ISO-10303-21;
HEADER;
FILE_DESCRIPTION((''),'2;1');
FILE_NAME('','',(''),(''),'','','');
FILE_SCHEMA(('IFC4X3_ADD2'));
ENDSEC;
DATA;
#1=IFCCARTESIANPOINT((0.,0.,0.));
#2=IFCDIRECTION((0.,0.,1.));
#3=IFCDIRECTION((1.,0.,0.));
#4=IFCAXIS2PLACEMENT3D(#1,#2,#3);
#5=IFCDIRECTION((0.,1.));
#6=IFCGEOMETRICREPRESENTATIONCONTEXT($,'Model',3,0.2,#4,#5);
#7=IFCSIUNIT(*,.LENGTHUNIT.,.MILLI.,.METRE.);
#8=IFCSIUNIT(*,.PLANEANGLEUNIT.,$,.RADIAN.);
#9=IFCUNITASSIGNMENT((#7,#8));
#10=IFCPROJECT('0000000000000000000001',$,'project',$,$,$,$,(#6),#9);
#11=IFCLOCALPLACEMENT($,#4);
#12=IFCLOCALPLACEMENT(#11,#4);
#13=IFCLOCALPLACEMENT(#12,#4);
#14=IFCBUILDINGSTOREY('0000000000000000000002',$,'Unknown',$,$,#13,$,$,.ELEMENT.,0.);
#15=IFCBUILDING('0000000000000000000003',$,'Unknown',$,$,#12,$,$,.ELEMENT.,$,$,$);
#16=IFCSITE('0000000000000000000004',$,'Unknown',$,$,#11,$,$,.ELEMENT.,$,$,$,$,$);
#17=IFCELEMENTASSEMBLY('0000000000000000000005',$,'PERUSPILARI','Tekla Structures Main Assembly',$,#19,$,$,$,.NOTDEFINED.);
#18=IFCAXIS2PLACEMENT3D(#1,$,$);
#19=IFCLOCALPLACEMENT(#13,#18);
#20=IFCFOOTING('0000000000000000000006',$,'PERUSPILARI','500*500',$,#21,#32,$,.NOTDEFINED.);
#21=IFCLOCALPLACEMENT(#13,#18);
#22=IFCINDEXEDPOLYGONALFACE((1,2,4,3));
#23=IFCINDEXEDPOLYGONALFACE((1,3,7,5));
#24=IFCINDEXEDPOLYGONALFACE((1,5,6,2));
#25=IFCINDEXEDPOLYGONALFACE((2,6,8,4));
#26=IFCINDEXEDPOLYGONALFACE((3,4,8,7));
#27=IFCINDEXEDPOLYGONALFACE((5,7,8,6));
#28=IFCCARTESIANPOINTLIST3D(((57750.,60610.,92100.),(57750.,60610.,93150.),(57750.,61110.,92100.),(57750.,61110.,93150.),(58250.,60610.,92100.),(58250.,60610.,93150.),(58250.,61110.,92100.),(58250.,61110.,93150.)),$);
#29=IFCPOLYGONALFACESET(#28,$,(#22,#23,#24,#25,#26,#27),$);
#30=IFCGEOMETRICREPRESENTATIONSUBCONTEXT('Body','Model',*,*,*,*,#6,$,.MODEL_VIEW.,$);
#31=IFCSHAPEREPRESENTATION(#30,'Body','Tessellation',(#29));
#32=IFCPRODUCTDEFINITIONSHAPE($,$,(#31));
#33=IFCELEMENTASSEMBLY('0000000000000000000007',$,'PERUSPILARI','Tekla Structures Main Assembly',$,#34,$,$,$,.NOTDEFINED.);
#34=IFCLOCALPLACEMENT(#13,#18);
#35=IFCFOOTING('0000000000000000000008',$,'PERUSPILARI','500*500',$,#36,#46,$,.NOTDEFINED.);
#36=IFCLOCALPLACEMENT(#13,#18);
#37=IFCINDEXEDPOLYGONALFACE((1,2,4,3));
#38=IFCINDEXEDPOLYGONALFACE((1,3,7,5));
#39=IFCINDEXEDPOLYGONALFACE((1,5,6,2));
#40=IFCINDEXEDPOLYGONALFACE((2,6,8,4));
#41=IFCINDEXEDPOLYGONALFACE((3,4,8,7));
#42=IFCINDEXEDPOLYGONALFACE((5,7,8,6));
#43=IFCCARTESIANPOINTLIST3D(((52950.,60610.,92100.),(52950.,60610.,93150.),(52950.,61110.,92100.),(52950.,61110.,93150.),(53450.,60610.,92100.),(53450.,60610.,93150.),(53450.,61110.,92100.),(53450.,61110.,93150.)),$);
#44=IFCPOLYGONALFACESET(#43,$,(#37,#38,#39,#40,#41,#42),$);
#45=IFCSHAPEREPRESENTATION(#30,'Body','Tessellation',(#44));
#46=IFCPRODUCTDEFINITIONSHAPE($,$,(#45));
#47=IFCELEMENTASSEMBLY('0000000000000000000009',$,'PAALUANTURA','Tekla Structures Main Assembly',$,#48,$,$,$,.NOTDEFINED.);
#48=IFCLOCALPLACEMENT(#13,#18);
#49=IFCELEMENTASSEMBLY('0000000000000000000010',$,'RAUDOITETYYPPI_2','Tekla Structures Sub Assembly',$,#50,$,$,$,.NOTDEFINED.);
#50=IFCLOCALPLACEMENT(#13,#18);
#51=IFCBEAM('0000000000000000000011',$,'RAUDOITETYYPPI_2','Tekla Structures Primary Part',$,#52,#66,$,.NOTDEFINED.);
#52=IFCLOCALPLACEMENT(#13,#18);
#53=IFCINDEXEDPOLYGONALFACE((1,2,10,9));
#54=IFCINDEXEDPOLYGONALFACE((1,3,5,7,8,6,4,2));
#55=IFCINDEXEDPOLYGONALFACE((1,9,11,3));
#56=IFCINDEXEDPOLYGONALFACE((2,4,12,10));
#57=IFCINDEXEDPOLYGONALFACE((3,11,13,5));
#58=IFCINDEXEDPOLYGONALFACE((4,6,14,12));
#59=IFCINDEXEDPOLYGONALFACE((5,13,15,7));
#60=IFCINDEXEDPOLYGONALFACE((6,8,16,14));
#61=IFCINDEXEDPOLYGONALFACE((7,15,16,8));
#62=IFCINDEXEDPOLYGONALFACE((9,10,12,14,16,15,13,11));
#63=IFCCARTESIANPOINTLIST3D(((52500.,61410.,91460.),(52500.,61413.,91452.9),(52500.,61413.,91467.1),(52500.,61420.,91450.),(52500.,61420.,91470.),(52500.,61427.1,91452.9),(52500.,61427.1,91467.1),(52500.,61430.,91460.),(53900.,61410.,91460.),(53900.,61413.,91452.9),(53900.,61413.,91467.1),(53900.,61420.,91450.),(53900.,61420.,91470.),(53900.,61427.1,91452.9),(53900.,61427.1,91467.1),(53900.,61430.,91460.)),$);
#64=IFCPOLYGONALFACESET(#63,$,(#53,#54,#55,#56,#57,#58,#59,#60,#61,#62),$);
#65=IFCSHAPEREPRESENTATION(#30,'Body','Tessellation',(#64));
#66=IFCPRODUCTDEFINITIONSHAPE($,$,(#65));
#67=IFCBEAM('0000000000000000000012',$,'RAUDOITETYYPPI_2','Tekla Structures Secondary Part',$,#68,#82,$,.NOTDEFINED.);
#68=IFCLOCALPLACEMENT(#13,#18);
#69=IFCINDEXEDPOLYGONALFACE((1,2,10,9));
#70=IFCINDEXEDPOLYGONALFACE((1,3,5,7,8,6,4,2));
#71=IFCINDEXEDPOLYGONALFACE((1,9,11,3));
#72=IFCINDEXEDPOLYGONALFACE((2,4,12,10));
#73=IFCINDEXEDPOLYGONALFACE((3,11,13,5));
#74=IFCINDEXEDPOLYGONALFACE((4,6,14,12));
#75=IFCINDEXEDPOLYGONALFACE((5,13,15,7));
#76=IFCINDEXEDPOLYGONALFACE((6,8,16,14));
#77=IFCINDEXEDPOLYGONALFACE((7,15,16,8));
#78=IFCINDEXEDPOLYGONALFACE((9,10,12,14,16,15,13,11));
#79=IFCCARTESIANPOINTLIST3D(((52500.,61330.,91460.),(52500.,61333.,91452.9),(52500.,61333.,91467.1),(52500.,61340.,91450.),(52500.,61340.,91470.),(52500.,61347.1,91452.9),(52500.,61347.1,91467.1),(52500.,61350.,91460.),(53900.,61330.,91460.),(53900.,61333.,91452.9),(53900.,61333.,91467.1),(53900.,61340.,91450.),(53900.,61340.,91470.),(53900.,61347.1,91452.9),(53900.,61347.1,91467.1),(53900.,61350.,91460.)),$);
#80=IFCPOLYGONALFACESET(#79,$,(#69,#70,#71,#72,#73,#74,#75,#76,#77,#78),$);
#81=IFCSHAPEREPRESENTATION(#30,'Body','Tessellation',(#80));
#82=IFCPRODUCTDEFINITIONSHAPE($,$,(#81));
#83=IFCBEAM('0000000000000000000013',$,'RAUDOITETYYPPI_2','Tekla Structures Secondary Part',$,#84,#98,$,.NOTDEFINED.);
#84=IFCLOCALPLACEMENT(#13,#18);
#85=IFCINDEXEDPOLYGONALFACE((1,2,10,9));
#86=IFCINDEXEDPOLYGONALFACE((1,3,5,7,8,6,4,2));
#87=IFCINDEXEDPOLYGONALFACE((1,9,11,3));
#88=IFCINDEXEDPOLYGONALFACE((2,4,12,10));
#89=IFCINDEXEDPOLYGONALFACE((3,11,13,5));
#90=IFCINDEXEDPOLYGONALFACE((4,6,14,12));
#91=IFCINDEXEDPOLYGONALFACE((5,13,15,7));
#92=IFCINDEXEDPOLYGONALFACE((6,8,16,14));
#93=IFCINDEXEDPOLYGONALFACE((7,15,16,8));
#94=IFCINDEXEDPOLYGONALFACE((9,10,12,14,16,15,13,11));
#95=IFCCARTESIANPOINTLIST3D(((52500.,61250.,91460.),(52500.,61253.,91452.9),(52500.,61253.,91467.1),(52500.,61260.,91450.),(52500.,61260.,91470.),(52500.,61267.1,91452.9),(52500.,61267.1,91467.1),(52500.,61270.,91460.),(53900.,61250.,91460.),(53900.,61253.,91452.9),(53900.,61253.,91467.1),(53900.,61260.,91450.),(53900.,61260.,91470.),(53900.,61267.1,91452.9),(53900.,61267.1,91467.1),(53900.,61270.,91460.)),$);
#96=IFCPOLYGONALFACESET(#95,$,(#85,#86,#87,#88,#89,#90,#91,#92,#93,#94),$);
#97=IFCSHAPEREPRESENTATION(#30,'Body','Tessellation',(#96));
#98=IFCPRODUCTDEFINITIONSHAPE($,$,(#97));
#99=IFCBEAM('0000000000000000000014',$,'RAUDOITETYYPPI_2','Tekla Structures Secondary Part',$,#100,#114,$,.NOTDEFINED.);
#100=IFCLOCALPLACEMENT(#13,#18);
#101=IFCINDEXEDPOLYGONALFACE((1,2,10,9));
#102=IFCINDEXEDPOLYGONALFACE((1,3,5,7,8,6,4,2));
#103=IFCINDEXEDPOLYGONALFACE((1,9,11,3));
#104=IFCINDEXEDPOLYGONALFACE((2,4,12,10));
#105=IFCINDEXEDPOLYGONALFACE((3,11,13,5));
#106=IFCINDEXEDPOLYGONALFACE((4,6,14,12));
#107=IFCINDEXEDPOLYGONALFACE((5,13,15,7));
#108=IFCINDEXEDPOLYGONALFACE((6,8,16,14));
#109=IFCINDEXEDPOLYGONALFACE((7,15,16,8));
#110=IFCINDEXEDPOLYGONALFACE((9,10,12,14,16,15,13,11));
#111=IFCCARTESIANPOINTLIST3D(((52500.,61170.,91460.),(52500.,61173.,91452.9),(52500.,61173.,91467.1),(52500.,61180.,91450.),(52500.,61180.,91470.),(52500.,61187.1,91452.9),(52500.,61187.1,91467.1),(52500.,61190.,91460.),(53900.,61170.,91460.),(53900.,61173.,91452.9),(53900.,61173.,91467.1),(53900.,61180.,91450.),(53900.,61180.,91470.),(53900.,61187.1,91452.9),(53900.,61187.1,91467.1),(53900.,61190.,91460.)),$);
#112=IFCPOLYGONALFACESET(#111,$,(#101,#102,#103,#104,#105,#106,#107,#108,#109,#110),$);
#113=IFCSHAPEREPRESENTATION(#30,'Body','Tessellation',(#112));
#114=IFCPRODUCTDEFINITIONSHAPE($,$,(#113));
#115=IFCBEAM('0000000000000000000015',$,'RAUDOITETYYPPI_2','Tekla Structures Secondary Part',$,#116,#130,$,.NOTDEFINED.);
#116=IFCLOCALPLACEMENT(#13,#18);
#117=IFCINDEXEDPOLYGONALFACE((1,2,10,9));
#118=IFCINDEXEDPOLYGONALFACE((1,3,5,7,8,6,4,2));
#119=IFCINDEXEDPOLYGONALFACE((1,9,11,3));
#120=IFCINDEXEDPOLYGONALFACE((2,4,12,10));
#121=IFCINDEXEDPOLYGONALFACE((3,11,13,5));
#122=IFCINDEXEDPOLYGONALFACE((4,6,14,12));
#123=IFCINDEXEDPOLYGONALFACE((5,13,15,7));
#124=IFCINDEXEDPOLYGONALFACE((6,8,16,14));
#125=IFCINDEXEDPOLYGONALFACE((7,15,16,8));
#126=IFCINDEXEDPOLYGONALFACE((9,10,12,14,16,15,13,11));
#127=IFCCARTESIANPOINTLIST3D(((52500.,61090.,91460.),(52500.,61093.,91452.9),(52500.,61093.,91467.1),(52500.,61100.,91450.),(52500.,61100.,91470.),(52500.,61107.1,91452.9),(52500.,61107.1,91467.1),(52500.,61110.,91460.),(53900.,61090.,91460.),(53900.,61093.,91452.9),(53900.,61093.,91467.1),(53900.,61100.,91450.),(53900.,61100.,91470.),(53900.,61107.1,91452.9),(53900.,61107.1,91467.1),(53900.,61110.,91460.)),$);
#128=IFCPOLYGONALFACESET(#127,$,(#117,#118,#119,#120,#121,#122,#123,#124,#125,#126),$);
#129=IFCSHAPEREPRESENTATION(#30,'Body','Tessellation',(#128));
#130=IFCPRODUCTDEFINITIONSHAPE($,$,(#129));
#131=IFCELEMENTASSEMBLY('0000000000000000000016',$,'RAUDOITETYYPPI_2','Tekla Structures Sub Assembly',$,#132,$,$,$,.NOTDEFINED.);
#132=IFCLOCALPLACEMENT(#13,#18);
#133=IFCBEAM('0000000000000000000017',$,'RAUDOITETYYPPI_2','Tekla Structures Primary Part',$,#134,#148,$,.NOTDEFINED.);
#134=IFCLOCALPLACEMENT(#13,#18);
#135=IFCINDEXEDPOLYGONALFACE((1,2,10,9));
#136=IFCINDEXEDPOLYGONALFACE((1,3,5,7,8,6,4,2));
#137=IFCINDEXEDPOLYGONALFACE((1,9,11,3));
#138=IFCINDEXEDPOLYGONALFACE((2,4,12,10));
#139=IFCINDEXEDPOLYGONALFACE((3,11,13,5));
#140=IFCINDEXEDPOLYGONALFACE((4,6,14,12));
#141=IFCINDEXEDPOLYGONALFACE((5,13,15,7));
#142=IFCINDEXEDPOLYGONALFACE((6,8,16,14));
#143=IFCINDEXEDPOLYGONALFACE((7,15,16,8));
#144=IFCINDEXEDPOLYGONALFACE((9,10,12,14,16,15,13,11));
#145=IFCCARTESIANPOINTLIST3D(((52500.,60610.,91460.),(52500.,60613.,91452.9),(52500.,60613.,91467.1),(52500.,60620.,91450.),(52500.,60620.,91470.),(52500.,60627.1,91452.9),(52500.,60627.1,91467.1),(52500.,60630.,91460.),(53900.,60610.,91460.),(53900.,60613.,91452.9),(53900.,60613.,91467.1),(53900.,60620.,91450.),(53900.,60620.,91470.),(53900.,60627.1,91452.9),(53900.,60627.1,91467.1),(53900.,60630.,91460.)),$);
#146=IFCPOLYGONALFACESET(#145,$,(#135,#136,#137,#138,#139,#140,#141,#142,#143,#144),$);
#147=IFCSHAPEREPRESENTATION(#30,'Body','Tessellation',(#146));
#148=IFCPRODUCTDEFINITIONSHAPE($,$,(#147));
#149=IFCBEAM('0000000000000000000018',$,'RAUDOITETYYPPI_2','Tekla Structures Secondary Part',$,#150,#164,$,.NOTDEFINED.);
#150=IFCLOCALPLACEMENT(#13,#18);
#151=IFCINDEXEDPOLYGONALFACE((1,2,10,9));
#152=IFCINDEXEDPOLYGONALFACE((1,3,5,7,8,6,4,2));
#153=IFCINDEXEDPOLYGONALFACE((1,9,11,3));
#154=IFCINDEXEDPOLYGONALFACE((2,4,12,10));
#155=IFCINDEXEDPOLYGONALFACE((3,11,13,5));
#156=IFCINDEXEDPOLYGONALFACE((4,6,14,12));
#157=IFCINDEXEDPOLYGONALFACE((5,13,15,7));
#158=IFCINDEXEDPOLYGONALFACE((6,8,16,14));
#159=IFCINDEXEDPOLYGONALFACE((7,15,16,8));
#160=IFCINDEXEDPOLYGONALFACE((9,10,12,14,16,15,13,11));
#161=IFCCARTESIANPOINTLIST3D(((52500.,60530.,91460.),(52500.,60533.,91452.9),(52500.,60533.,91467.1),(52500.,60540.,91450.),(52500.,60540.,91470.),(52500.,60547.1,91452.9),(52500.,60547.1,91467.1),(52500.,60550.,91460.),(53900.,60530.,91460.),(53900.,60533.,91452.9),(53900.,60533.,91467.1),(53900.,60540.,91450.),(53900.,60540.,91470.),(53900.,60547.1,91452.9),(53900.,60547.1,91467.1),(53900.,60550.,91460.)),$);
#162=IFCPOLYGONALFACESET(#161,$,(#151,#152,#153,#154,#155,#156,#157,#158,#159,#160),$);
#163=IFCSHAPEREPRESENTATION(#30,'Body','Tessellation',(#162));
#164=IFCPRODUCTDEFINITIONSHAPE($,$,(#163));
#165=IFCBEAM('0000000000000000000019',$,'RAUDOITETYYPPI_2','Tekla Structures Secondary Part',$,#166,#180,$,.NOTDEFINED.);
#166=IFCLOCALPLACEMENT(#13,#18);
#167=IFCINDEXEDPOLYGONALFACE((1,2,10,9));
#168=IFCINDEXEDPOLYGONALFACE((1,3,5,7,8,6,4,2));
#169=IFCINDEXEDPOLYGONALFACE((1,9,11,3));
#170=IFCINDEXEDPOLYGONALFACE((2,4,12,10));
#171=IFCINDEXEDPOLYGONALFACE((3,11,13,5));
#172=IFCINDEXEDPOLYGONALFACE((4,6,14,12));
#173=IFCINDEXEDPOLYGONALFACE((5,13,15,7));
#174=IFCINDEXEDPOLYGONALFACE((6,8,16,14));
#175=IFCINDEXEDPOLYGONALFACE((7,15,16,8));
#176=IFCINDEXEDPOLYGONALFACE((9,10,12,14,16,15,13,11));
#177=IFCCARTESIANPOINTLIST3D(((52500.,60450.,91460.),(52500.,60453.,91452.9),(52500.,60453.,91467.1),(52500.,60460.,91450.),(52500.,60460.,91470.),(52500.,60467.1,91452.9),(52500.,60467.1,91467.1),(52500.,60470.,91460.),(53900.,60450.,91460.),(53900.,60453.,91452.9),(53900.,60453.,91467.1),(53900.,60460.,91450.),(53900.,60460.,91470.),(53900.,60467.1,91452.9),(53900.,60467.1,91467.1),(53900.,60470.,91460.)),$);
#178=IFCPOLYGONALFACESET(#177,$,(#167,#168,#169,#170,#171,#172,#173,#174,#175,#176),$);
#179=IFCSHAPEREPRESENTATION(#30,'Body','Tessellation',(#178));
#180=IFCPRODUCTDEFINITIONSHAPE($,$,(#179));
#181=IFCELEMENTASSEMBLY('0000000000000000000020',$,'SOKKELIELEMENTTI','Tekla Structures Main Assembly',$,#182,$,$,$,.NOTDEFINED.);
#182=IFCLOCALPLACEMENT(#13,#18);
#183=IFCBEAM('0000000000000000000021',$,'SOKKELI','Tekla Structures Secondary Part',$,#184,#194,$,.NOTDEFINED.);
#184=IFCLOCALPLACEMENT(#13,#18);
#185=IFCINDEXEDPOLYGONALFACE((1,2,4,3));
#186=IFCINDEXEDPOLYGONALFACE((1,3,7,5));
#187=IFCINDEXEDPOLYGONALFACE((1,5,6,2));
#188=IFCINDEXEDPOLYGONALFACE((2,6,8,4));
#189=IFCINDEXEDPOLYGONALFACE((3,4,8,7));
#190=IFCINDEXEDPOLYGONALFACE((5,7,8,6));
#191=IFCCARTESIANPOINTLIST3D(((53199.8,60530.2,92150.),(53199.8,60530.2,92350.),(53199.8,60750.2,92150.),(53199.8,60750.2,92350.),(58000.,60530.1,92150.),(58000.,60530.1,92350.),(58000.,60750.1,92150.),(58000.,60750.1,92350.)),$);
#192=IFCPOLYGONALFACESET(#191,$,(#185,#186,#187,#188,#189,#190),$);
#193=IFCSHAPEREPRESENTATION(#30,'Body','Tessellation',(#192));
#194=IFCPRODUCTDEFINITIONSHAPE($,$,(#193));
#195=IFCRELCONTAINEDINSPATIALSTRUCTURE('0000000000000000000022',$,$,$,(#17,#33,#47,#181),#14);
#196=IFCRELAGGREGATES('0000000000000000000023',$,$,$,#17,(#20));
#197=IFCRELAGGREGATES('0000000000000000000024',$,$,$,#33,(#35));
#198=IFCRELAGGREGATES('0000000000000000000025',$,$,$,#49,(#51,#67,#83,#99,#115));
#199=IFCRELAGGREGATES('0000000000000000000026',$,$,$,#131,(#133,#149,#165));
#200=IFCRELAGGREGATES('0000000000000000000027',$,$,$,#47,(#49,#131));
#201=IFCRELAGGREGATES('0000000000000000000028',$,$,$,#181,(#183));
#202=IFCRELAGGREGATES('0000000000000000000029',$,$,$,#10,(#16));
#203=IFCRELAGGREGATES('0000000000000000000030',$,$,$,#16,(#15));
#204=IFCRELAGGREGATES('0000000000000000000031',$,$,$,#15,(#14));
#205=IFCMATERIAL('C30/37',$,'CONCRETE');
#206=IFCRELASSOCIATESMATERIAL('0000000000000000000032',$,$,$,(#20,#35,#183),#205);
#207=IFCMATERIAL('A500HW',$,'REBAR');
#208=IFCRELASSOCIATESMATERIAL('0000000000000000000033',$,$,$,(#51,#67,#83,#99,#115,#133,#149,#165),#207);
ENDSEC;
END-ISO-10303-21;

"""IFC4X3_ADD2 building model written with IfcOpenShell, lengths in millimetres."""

from ifc_helpers import new_model, si_unit, direction, frame, origin_with_axes, place, context, subcontext, project, spatial, line, indexed_curve, outline, extrude, material, element, aggregate, save


model = new_model("IFC4X3_ADD2")

# Units and contexts
model_context = context("Model", 3, precision=0.2, world=origin_with_axes(), true_north=direction((0.0, 1.0)))
body_context = subcontext(model_context, "Body", "Model", "MODEL_VIEW")
ifc_project = project(units=[si_unit("LENGTHUNIT", "METRE", prefix="MILLI"), si_unit("PLANEANGLEUNIT", "RADIAN")], contexts=[model_context])

# Site, building, storey
site_placement = place(None, origin_with_axes())
site = spatial("IfcSite", under=ifc_project, at=site_placement, Name="Unknown", CompositionType="ELEMENT")
building_placement = place(site_placement, origin_with_axes())
building = spatial("IfcBuilding", under=site, at=building_placement, Name="Unknown", CompositionType="ELEMENT")
storey_placement = place(building_placement, origin_with_axes())
storey = spatial("IfcBuildingStorey", under=building, at=storey_placement, Name="Unknown", CompositionType="ELEMENT", Elevation=0.0)

# Element assemblies, footings
assembly_1_placement = place(storey_placement, frame((58000.0, 60860.0, 92100.0), z_axis=(-1.0, 0.0, 0.0), x_axis=(0.0, 0.0, 1.0)))
assembly_1 = element("IfcElementAssembly", 1, at=assembly_1_placement, inside=storey, Name="PERUSPILARI", Description="Tekla Structures Main Assembly", PredefinedType="NOTDEFINED")
ifc_material_1 = material(Name="C30/37", Category="CONCRETE")
footing_1_placement = place(assembly_1_placement, origin_with_axes())
footing_1 = element("IfcFooting", 2, at=footing_1_placement, material=ifc_material_1, Name="PERUSPILARI", Description="500*500", PredefinedType="NOTDEFINED", context=body_context, shape_type="SolidModel", body=[
    extrude(outline(indexed_curve([(-250.0, -250.0), (250.0, -250.0), (250.0, 250.0), (-250.0, 250.0)], segments=[line(1, 2, 3, 4, 1)])), frame((0.0, 0.0, 0.0), z_axis=(-1.0, 0.0, 0.0), x_axis=(0.0, 0.0, 1.0)), (0.0, 0.0, -1.0), 1050.0),
])
aggregate(assembly_1, [footing_1])
assembly_2_placement = place(storey_placement, frame((53200.0, 60860.0, 92100.0), z_axis=(-1.0, 0.0, 0.0), x_axis=(0.0, 0.0, 1.0)))
assembly_2 = element("IfcElementAssembly", 3, at=assembly_2_placement, inside=storey, Name="PERUSPILARI", Description="Tekla Structures Main Assembly", PredefinedType="NOTDEFINED")
footing_2_placement = place(assembly_2_placement, origin_with_axes())
footing_2 = element("IfcFooting", 4, at=footing_2_placement, material=ifc_material_1, Name="PERUSPILARI", Description="500*500", PredefinedType="NOTDEFINED", context=body_context, shape_type="SolidModel", body=[
    extrude(outline(indexed_curve([(-250.0, -250.0), (250.0, -250.0), (250.0, 250.0), (-250.0, 250.0)], segments=[line(1, 2, 3, 4, 1)])), frame((0.0, 0.0, 0.0), z_axis=(-1.0, 0.0, 0.0), x_axis=(0.0, 0.0, 1.0)), (0.0, 0.0, -1.0), 1050.0),
])
aggregate(assembly_2, [footing_2])

# Element assemblies, beams
ifc_material_2 = material(Name="A500HW", Category="REBAR")
assembly_3_placement = place(storey_placement, frame((53200.0, 60860.0, 92100.0), z_axis=(0.0, -1.0, 0.0), x_axis=(0.0, 0.0, -1.0)))
assembly_3 = element("IfcElementAssembly", 5, at=assembly_3_placement, inside=storey, Name="PAALUANTURA", Description="Tekla Structures Main Assembly", PredefinedType="NOTDEFINED")
assembly_4_placement = place(assembly_3_placement, frame((640.0, 700.0, -560.0), z_axis=(-1.0, 0.0, 0.0), x_axis=(0.0, -1.0, 0.0)))
assembly_4 = element("IfcElementAssembly", 6, at=assembly_4_placement, Name="RAUDOITETYYPPI_2", Description="Tekla Structures Sub Assembly", PredefinedType="NOTDEFINED")
beam_1_placement = place(assembly_4_placement, origin_with_axes())
beam_1 = element("IfcBeam", 7, at=beam_1_placement, material=ifc_material_2, Name="RAUDOITETYYPPI_2", Description="Tekla Structures Primary Part", PredefinedType="NOTDEFINED", context=body_context, shape_type="SolidModel", body=[
    extrude(outline(indexed_curve([(10.0, 0.0), (7.1, 7.1), (0.0, 10.0), (-7.1, 7.1), (-10.0, 0.0), (-7.1, -7.1), (0.0, -10.0), (7.1, -7.1)], segments=[line(1, 2, 3, 4, 5, 6, 7, 8, 1)])), frame((0.0, 0.0, 0.0), z_axis=(-1.0, 0.0, 0.0), x_axis=(0.0, 0.0, 1.0)), (0.0, 0.0, -1.0), 1400.0),
])
beam_2_placement = place(assembly_4_placement, frame((0.0, 80.0, 0.0), z_axis=(0.0, 0.0, 1.0), x_axis=(1.0, 0.0, 0.0)))
beam_2 = element("IfcBeam", 8, at=beam_2_placement, material=ifc_material_2, Name="RAUDOITETYYPPI_2", Description="Tekla Structures Secondary Part", PredefinedType="NOTDEFINED", context=body_context, shape_type="SolidModel", body=[
    extrude(outline(indexed_curve([(10.0, 0.0), (7.1, 7.1), (0.0, 10.0), (-7.1, 7.1), (-10.0, 0.0), (-7.1, -7.1), (0.0, -10.0), (7.1, -7.1)], segments=[line(1, 2, 3, 4, 5, 6, 7, 8, 1)])), frame((0.0, 0.0, 0.0), z_axis=(-1.0, 0.0, 0.0), x_axis=(0.0, 0.0, 1.0)), (0.0, 0.0, -1.0), 1400.0),
])
beam_3_placement = place(assembly_4_placement, frame((0.0, 160.0, 0.0), z_axis=(0.0, 0.0, 1.0), x_axis=(1.0, 0.0, 0.0)))
beam_3 = element("IfcBeam", 9, at=beam_3_placement, material=ifc_material_2, Name="RAUDOITETYYPPI_2", Description="Tekla Structures Secondary Part", PredefinedType="NOTDEFINED", context=body_context, shape_type="SolidModel", body=[
    extrude(outline(indexed_curve([(10.0, 0.0), (7.1, 7.1), (0.0, 10.0), (-7.1, 7.1), (-10.0, 0.0), (-7.1, -7.1), (0.0, -10.0), (7.1, -7.1)], segments=[line(1, 2, 3, 4, 5, 6, 7, 8, 1)])), frame((0.0, 0.0, 0.0), z_axis=(-1.0, 0.0, 0.0), x_axis=(0.0, 0.0, 1.0)), (0.0, 0.0, -1.0), 1400.0),
])
beam_4_placement = place(assembly_4_placement, frame((0.0, 240.0, 0.0), z_axis=(0.0, 0.0, 1.0), x_axis=(1.0, 0.0, 0.0)))
beam_4 = element("IfcBeam", 10, at=beam_4_placement, material=ifc_material_2, Name="RAUDOITETYYPPI_2", Description="Tekla Structures Secondary Part", PredefinedType="NOTDEFINED", context=body_context, shape_type="SolidModel", body=[
    extrude(outline(indexed_curve([(10.0, 0.0), (7.1, 7.1), (0.0, 10.0), (-7.1, 7.1), (-10.0, 0.0), (-7.1, -7.1), (0.0, -10.0), (7.1, -7.1)], segments=[line(1, 2, 3, 4, 5, 6, 7, 8, 1)])), frame((0.0, 0.0, 0.0), z_axis=(-1.0, 0.0, 0.0), x_axis=(0.0, 0.0, 1.0)), (0.0, 0.0, -1.0), 1400.0),
])
beam_5_placement = place(assembly_4_placement, frame((0.0, 320.0, 0.0), z_axis=(0.0, 0.0, 1.0), x_axis=(1.0, 0.0, 0.0)))
beam_5 = element("IfcBeam", 11, at=beam_5_placement, material=ifc_material_2, Name="RAUDOITETYYPPI_2", Description="Tekla Structures Secondary Part", PredefinedType="NOTDEFINED", context=body_context, shape_type="SolidModel", body=[
    extrude(outline(indexed_curve([(10.0, 0.0), (7.1, 7.1), (0.0, 10.0), (-7.1, 7.1), (-10.0, 0.0), (-7.1, -7.1), (0.0, -10.0), (7.1, -7.1)], segments=[line(1, 2, 3, 4, 5, 6, 7, 8, 1)])), frame((0.0, 0.0, 0.0), z_axis=(-1.0, 0.0, 0.0), x_axis=(0.0, 0.0, 1.0)), (0.0, 0.0, -1.0), 1400.0),
])
aggregate(assembly_4, [beam_1, beam_2, beam_3, beam_4, beam_5])
assembly_5_placement = place(assembly_3_placement, frame((640.0, 700.0, 240.0), z_axis=(-1.0, 0.0, 0.0), x_axis=(0.0, -1.0, 0.0)))
assembly_5 = element("IfcElementAssembly", 12, at=assembly_5_placement, Name="RAUDOITETYYPPI_2", Description="Tekla Structures Sub Assembly", PredefinedType="NOTDEFINED")
beam_6_placement = place(assembly_5_placement, origin_with_axes())
beam_6 = element("IfcBeam", 13, at=beam_6_placement, material=ifc_material_2, Name="RAUDOITETYYPPI_2", Description="Tekla Structures Primary Part", PredefinedType="NOTDEFINED", context=body_context, shape_type="SolidModel", body=[
    extrude(outline(indexed_curve([(10.0, 0.0), (7.1, 7.1), (0.0, 10.0), (-7.1, 7.1), (-10.0, 0.0), (-7.1, -7.1), (0.0, -10.0), (7.1, -7.1)], segments=[line(1, 2, 3, 4, 5, 6, 7, 8, 1)])), frame((0.0, 0.0, 0.0), z_axis=(-1.0, 0.0, 0.0), x_axis=(0.0, 0.0, 1.0)), (0.0, 0.0, -1.0), 1400.0),
])
beam_7_placement = place(assembly_5_placement, frame((0.0, 80.0, 0.0), z_axis=(0.0, 0.0, 1.0), x_axis=(1.0, 0.0, 0.0)))
beam_7 = element("IfcBeam", 14, at=beam_7_placement, material=ifc_material_2, Name="RAUDOITETYYPPI_2", Description="Tekla Structures Secondary Part", PredefinedType="NOTDEFINED", context=body_context, shape_type="SolidModel", body=[
    extrude(outline(indexed_curve([(10.0, 0.0), (7.1, 7.1), (0.0, 10.0), (-7.1, 7.1), (-10.0, 0.0), (-7.1, -7.1), (0.0, -10.0), (7.1, -7.1)], segments=[line(1, 2, 3, 4, 5, 6, 7, 8, 1)])), frame((0.0, 0.0, 0.0), z_axis=(-1.0, 0.0, 0.0), x_axis=(0.0, 0.0, 1.0)), (0.0, 0.0, -1.0), 1400.0),
])
beam_8_placement = place(assembly_5_placement, frame((0.0, 160.0, 0.0), z_axis=(0.0, 0.0, 1.0), x_axis=(1.0, 0.0, 0.0)))
beam_8 = element("IfcBeam", 15, at=beam_8_placement, material=ifc_material_2, Name="RAUDOITETYYPPI_2", Description="Tekla Structures Secondary Part", PredefinedType="NOTDEFINED", context=body_context, shape_type="SolidModel", body=[
    extrude(outline(indexed_curve([(10.0, 0.0), (7.1, 7.1), (0.0, 10.0), (-7.1, 7.1), (-10.0, 0.0), (-7.1, -7.1), (0.0, -10.0), (7.1, -7.1)], segments=[line(1, 2, 3, 4, 5, 6, 7, 8, 1)])), frame((0.0, 0.0, 0.0), z_axis=(-1.0, 0.0, 0.0), x_axis=(0.0, 0.0, 1.0)), (0.0, 0.0, -1.0), 1400.0),
])
aggregate(assembly_5, [beam_6, beam_7, beam_8])
aggregate(assembly_3, [assembly_4, assembly_5])

# Element assembly, beam
assembly_6_placement = place(storey_placement, frame((58000.0, 60810.1, 92950.0), z_axis=(0.000027, 1.0, 0.0), x_axis=(-1.0, 0.000027, 0.0)))
assembly_6 = element("IfcElementAssembly", 16, at=assembly_6_placement, inside=storey, Name="SOKKELIELEMENTTI", Description="Tekla Structures Main Assembly", PredefinedType="NOTDEFINED")
beam_9_placement = place(assembly_6_placement, frame((0.0, -700.0, -170.0), z_axis=(0.0, 0.0, 1.0), x_axis=(1.0, 0.0, 0.0)))
beam_9 = element("IfcBeam", 17, at=beam_9_placement, material=ifc_material_1, Name="SOKKELI", Description="Tekla Structures Secondary Part", PredefinedType="NOTDEFINED", context=body_context, shape_type="SolidModel", body=[
    extrude(outline(indexed_curve([(-110.0, -100.0), (110.0, -100.0), (110.0, 100.0), (-110.0, 100.0)], segments=[line(1, 2, 3, 4, 1)])), frame((0.0, 0.0, 0.0), z_axis=(-1.0, 0.0, 0.0), x_axis=(0.0, 0.0, 1.0)), (0.0, 0.0, -1.0), 4800.1),
])
aggregate(assembly_6, [beam_9])

save(model, "model.ifc")
